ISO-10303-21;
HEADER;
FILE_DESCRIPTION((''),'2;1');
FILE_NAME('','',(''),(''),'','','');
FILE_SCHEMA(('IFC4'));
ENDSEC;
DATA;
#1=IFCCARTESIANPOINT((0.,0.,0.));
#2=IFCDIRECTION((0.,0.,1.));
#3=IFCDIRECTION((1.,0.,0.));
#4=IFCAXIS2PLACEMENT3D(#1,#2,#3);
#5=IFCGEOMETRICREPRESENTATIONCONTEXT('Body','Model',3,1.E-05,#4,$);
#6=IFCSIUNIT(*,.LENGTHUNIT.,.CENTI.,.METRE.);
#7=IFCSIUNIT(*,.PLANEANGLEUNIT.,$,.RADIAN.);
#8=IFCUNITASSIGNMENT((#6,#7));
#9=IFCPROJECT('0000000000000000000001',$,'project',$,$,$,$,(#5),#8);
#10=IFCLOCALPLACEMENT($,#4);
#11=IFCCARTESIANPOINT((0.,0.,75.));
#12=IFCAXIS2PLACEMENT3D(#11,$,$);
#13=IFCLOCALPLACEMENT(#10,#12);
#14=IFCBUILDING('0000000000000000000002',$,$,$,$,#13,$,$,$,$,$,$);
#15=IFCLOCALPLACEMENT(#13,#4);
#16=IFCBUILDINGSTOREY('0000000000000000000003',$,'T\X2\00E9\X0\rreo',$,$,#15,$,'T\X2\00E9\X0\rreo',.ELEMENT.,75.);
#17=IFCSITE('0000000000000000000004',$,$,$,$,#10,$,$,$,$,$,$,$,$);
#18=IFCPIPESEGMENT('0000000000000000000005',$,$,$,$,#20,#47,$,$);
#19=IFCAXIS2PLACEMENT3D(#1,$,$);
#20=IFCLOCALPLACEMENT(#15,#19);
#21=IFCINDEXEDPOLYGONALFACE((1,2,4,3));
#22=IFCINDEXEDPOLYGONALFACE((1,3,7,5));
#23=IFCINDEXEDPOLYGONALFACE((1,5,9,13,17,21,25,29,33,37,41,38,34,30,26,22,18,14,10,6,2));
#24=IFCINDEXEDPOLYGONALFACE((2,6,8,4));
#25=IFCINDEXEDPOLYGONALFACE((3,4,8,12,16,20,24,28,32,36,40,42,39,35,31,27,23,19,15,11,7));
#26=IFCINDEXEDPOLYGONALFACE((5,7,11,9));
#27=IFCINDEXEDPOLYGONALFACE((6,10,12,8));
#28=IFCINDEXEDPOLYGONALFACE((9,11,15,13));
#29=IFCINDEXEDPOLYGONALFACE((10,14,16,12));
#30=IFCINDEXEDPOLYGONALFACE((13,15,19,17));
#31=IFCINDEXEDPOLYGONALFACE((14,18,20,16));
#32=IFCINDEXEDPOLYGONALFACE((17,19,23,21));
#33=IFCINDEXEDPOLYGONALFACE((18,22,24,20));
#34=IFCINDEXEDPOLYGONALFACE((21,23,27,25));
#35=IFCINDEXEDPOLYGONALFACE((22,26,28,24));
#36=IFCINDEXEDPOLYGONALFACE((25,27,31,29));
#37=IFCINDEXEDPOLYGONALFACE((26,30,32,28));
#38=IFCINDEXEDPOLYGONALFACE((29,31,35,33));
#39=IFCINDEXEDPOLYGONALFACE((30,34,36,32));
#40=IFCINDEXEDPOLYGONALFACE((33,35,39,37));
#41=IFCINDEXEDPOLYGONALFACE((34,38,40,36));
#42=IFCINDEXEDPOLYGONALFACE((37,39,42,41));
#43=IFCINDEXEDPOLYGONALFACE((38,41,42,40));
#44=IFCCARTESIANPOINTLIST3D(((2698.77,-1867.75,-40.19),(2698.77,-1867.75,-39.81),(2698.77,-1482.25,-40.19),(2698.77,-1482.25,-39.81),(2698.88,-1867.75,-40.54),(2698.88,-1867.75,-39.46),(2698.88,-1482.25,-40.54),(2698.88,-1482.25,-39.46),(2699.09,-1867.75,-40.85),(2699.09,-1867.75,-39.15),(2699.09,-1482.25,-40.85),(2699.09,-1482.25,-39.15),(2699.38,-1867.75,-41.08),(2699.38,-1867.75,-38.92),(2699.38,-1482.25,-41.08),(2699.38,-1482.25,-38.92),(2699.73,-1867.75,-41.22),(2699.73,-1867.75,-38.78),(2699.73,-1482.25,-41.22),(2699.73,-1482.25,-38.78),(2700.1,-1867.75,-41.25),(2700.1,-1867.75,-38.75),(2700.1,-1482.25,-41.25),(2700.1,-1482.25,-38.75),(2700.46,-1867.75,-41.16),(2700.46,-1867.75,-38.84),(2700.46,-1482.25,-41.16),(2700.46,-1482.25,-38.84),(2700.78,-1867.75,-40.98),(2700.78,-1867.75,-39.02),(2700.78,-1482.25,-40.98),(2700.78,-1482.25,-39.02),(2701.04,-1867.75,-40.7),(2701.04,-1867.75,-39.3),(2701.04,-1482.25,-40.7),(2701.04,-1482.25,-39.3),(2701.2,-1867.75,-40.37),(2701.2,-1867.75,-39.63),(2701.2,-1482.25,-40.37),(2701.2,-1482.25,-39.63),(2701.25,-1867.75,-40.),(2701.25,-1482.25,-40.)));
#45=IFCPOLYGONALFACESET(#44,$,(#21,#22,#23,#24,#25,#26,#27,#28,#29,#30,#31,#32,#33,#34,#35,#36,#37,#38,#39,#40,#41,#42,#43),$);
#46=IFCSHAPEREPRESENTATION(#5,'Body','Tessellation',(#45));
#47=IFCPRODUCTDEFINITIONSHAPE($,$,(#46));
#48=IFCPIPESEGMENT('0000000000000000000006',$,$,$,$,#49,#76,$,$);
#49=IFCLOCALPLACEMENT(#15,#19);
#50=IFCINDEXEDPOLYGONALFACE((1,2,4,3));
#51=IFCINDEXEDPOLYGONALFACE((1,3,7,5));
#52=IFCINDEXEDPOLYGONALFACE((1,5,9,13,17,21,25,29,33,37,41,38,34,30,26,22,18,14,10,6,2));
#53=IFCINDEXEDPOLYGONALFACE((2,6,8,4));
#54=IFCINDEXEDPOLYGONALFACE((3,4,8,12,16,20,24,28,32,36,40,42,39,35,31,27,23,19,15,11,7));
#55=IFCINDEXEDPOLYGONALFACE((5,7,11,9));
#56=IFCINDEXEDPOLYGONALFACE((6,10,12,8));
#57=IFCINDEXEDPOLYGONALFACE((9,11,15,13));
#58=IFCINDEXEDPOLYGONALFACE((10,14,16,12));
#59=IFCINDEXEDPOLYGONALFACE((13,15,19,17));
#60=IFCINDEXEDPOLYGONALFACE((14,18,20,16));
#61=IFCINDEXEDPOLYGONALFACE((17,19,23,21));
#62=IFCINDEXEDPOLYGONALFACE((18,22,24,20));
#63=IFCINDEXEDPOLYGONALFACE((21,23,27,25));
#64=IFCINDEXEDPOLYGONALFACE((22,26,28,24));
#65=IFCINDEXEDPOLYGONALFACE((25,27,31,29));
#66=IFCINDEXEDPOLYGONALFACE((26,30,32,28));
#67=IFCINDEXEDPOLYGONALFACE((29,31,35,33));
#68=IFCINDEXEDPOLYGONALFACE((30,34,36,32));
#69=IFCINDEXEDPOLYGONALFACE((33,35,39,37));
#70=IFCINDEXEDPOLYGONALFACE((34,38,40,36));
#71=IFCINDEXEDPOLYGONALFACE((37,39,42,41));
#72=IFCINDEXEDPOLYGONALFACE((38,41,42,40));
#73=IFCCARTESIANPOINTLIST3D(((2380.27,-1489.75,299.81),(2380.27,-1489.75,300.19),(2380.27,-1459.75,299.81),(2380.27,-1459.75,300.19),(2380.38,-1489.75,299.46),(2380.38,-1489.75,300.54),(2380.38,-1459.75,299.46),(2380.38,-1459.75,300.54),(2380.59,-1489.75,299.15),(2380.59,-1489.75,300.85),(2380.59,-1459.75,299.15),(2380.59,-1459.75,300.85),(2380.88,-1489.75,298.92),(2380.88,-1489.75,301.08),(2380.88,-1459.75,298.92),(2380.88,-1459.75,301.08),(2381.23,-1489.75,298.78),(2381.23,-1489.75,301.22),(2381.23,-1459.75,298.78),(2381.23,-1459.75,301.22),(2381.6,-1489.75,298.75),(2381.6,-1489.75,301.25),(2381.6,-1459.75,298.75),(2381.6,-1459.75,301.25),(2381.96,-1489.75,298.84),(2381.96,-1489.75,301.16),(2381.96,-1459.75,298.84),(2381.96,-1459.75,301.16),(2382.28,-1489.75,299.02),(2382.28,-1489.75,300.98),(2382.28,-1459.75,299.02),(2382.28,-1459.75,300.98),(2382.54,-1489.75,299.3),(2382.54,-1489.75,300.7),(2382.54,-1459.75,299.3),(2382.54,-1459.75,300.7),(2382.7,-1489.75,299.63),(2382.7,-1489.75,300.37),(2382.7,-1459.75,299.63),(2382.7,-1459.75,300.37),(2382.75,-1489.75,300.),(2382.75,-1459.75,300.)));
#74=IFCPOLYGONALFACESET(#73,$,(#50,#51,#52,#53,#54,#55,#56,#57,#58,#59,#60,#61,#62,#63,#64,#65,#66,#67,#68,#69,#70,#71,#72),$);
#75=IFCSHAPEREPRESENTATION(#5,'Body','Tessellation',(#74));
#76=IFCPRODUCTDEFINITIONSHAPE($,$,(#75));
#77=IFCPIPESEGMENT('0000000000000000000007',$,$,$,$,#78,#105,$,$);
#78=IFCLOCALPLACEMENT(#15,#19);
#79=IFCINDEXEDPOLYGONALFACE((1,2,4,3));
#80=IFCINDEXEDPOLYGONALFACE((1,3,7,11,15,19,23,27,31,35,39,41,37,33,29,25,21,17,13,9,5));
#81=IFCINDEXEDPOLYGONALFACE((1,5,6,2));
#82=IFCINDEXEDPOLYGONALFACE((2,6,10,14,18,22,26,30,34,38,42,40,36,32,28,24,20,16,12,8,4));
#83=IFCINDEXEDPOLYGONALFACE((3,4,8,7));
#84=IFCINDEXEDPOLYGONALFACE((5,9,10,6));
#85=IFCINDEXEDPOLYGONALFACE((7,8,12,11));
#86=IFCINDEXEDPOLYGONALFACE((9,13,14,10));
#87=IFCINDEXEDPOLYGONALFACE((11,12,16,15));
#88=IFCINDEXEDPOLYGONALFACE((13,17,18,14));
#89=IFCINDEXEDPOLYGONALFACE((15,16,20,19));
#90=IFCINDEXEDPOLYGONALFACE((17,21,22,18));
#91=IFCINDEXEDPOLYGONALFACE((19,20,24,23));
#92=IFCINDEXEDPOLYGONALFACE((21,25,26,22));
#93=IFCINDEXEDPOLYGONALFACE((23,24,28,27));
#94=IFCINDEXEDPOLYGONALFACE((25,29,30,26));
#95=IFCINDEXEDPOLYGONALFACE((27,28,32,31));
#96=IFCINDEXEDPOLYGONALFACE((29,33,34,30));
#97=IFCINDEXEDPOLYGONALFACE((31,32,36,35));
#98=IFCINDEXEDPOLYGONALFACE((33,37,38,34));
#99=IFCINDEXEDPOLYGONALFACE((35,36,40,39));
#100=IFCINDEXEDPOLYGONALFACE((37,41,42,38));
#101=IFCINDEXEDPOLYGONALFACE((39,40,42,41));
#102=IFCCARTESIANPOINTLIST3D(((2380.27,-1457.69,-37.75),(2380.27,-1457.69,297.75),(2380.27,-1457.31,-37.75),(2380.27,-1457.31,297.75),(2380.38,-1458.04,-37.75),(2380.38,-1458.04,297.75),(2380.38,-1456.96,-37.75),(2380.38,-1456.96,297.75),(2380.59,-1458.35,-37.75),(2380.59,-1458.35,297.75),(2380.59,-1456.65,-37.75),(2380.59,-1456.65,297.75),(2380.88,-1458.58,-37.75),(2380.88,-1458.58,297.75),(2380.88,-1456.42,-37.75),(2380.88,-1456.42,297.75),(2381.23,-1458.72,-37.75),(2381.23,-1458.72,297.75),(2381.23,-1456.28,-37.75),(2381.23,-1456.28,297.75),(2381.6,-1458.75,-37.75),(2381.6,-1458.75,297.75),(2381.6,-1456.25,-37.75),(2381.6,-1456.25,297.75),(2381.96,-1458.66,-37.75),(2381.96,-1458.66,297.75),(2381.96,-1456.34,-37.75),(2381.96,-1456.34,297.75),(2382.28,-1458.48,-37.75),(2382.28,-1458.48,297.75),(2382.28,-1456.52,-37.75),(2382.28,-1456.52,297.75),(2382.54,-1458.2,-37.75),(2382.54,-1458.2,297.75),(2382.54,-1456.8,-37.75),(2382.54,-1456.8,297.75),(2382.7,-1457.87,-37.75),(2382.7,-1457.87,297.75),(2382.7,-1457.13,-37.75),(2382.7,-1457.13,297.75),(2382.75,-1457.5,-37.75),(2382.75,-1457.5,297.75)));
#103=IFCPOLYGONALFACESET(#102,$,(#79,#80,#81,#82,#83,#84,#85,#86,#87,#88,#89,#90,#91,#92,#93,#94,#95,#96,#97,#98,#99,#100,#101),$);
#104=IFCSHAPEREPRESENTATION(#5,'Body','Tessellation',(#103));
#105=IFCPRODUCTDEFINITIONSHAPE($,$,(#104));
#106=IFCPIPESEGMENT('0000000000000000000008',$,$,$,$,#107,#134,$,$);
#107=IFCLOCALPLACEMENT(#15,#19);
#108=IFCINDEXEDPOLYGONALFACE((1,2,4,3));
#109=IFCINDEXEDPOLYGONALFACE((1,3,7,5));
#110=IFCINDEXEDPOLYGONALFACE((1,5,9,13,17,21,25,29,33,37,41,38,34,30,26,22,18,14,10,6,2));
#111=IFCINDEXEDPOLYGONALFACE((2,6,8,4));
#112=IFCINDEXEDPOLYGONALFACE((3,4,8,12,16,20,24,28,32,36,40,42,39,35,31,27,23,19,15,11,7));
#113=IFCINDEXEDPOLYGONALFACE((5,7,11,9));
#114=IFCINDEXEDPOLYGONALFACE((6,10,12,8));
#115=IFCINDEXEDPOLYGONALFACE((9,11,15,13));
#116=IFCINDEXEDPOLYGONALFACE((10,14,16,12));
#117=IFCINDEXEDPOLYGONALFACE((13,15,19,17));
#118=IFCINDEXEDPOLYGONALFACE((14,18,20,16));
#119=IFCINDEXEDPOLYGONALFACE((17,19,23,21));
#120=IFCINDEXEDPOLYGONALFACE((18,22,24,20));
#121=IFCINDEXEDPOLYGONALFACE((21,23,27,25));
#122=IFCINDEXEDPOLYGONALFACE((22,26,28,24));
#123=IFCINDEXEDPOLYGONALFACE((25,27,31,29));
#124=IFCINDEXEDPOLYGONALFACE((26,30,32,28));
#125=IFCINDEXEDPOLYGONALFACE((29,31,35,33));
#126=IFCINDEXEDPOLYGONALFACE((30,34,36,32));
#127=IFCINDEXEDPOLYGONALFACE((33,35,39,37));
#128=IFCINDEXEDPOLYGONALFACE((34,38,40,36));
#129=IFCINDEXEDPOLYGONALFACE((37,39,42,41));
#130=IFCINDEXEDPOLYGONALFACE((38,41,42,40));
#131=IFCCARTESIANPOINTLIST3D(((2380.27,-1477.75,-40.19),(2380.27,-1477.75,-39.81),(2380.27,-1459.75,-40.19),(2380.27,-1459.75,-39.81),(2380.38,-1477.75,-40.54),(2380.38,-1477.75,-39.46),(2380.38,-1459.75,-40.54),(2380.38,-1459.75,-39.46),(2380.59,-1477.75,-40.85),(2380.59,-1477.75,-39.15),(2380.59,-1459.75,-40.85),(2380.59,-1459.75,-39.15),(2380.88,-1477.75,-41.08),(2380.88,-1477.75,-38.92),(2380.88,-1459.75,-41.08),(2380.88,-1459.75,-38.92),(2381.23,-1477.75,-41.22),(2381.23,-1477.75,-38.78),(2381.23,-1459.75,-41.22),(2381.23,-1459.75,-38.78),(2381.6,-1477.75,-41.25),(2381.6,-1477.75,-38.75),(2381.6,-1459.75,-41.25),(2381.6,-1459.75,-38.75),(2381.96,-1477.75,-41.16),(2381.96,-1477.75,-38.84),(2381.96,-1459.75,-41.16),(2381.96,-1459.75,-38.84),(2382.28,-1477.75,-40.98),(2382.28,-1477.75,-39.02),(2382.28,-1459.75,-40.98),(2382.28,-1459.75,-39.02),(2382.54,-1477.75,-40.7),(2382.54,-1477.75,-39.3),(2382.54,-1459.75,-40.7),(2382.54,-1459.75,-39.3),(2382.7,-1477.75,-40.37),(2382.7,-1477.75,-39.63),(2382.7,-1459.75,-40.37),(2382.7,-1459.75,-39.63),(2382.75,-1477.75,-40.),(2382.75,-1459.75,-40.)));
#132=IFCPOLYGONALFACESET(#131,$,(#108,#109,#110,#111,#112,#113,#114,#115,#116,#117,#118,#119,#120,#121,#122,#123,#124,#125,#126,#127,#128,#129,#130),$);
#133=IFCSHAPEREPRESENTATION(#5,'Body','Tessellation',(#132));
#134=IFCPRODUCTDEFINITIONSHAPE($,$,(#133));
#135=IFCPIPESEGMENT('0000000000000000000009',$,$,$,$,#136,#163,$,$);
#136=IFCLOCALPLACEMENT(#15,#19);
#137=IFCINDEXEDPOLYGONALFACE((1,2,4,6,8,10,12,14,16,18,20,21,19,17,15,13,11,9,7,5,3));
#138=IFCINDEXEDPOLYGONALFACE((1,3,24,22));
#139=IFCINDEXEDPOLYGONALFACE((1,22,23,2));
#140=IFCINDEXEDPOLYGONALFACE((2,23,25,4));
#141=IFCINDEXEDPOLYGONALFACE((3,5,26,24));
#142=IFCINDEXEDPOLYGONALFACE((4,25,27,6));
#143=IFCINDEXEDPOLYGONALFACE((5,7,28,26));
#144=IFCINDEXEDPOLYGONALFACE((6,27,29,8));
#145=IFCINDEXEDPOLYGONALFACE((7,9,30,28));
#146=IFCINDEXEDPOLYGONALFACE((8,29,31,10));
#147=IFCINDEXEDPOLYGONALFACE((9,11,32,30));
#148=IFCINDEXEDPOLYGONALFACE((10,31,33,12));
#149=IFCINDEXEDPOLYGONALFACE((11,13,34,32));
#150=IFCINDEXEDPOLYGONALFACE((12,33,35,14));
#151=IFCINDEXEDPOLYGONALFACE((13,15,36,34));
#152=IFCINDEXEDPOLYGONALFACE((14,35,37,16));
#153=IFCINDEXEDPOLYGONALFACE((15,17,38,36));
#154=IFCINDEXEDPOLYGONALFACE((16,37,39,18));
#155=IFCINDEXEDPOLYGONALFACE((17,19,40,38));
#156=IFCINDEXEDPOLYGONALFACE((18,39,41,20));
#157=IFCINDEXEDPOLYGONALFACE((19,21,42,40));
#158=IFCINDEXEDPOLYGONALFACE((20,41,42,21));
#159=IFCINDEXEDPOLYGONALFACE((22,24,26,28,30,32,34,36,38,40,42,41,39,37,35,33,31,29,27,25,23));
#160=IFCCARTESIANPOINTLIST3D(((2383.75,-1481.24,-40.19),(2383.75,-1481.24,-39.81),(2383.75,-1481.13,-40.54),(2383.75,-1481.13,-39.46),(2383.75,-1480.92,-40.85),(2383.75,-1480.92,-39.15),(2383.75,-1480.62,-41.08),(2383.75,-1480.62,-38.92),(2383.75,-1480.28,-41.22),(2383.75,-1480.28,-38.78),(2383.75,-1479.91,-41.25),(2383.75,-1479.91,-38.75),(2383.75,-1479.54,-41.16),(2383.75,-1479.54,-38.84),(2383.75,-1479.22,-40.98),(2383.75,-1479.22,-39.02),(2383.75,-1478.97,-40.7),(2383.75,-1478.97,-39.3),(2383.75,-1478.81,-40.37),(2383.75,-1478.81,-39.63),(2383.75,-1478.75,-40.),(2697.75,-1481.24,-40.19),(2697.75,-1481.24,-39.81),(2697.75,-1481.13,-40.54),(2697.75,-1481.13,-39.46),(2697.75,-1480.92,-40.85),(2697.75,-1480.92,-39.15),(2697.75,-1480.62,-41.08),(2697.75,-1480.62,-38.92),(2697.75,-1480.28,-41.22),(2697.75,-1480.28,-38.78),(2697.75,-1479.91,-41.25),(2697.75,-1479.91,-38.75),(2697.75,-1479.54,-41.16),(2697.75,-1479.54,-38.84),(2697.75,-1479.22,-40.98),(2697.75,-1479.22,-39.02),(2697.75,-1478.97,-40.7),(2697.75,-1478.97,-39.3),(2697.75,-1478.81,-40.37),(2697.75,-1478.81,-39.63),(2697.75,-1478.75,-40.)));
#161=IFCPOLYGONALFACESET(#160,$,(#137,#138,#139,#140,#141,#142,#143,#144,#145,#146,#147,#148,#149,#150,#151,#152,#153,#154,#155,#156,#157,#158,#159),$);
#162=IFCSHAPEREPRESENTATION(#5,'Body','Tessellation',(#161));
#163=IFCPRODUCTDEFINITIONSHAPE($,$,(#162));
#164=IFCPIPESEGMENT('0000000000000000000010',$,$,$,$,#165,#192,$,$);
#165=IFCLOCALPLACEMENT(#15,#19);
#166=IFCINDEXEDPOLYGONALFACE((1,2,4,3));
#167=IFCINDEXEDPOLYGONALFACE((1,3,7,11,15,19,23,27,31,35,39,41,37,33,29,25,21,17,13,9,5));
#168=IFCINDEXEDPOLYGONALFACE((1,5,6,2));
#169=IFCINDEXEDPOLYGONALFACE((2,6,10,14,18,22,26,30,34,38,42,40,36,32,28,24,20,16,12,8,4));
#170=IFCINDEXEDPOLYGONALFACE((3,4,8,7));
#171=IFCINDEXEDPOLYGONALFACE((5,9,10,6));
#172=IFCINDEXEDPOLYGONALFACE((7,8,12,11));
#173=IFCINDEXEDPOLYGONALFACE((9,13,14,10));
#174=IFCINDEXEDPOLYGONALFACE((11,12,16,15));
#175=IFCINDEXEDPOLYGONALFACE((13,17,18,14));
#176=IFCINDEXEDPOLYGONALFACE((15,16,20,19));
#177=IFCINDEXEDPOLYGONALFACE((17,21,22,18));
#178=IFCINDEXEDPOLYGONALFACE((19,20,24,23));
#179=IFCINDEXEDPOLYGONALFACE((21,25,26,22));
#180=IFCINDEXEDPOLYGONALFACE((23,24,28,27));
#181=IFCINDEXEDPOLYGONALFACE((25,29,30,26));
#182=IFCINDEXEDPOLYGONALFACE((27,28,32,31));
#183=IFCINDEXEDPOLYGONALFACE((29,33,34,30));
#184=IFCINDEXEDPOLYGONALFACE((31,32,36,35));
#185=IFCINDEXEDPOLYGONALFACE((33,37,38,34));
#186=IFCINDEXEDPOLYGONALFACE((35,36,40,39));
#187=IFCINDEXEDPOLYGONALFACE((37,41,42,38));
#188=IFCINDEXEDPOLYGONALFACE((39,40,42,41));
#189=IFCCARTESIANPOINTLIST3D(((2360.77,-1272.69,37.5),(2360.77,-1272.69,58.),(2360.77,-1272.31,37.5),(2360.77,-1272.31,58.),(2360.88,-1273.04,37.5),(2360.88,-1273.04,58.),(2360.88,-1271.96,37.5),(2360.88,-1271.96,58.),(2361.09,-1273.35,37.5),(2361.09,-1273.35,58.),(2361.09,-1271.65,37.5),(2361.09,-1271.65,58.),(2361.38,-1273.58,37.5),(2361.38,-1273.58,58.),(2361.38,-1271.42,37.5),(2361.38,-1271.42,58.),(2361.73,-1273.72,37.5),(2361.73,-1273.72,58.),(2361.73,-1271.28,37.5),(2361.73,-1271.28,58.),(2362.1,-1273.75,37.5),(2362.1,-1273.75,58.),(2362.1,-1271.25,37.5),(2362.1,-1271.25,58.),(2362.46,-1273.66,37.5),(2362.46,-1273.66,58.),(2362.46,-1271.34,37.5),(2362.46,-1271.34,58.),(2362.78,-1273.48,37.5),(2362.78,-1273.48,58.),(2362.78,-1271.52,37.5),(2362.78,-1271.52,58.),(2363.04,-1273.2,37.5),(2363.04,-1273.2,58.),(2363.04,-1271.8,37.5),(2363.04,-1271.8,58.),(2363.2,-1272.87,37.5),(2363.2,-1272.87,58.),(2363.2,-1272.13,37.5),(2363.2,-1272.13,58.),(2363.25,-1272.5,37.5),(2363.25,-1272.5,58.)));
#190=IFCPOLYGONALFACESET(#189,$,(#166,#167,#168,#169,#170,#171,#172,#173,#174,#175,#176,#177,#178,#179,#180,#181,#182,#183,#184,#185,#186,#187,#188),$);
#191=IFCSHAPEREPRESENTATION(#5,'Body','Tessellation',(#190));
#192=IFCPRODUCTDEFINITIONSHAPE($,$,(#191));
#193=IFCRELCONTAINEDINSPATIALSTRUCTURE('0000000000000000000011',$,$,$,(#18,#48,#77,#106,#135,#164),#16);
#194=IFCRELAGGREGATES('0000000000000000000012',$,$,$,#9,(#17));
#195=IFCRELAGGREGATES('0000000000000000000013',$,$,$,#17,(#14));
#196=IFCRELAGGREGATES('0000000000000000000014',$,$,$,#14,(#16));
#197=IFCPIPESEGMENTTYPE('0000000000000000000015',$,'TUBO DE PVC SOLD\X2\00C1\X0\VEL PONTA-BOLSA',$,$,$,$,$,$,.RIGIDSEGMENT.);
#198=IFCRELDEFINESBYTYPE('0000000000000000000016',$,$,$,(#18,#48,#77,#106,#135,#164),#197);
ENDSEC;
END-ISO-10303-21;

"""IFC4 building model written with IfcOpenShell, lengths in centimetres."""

from ifc_helpers import new_model, si_unit, frame, origin_with_axes, origin_2d_with_axis, place, context, project, spatial, circle, extrude, type_object, element, save


model = new_model("IFC4")

# Units and contexts
model_context = context("Model", 3, precision=1e-05, world=origin_with_axes(), identifier="Body")
ifc_project = project(units=[si_unit("LENGTHUNIT", "METRE", prefix="CENTI"), si_unit("PLANEANGLEUNIT", "RADIAN")], contexts=[model_context])

# Site, building, storey
site_placement = place(None, origin_with_axes())
site = spatial("IfcSite", under=ifc_project, at=site_placement)
building_placement = place(site_placement, frame((0.0, 0.0, 75.0)))
building = spatial("IfcBuilding", under=site, at=building_placement)
storey_placement = place(building_placement, origin_with_axes())
storey = spatial("IfcBuildingStorey", under=building, at=storey_placement, Name="Térreo", LongName="Térreo", CompositionType="ELEMENT", Elevation=75.0)

# Pipe segments
pipe_segment_type_1 = type_object("IfcPipeSegmentType", Name="TUBO DE PVC SOLDÁVEL PONTA-BOLSA", PredefinedType="RIGIDSEGMENT")
pipe_segment_1_placement = place(storey_placement, frame((2700.0, -1675.0, -38.75), z_axis=(0.0, 0.0, 1.0), x_axis=(1.0, 0.0, 0.0)))
element("IfcPipeSegment", 1, at=pipe_segment_1_placement, inside=storey, type_object=pipe_segment_type_1, context=model_context, shape_type="SolidModel", body=[
    extrude(circle(Radius=1.25, at=origin_2d_with_axis()), frame((0.0, -192.75, -1.25), z_axis=(0.0, 1.0, 0.0), x_axis=(1.0, 0.0, 0.0)), (0.0, 0.0, 1.0), 385.5),
])
pipe_segment_2_placement = place(storey_placement, frame((2381.5, -1474.75, 301.25), z_axis=(0.0, 0.0, 1.0), x_axis=(1.0, 0.0, 0.0)))
element("IfcPipeSegment", 2, at=pipe_segment_2_placement, inside=storey, type_object=pipe_segment_type_1, context=model_context, shape_type="SolidModel", body=[
    extrude(circle(Radius=1.25, at=origin_2d_with_axis()), frame((0.0, 15.0, -1.25), z_axis=(0.0, -1.0, 0.0), x_axis=(1.0, 0.0, 0.0)), (0.0, 0.0, 1.0), 30.0),
])
pipe_segment_3_placement = place(storey_placement, frame((2381.5, -1457.5, 297.75), z_axis=(0.0, 0.0, 1.0), x_axis=(1.0, 0.0, 0.0)))
element("IfcPipeSegment", 3, at=pipe_segment_3_placement, inside=storey, type_object=pipe_segment_type_1, context=model_context, shape_type="SolidModel", body=[
    extrude(circle(Radius=1.25, at=origin_2d_with_axis()), frame((0.0, 0.0, -335.5), z_axis=(0.0, 0.0, 1.0), x_axis=(1.0, 0.0, 0.0)), (0.0, 0.0, 1.0), 335.5),
])
pipe_segment_4_placement = place(storey_placement, frame((2381.5, -1468.75, -38.75), z_axis=(0.0, 0.0, 1.0), x_axis=(1.0, 0.0, 0.0)))
element("IfcPipeSegment", 4, at=pipe_segment_4_placement, inside=storey, type_object=pipe_segment_type_1, context=model_context, shape_type="SolidModel", body=[
    extrude(circle(Radius=1.25, at=origin_2d_with_axis()), frame((0.0, -9.0, -1.25), z_axis=(0.0, 1.0, 0.0), x_axis=(1.0, 0.0, 0.0)), (0.0, 0.0, 1.0), 18.0),
])
pipe_segment_5_placement = place(storey_placement, frame((2540.75, -1480.0, -38.75), z_axis=(0.0, 0.0, 1.0), x_axis=(1.0, 0.0, 0.0)))
element("IfcPipeSegment", 5, at=pipe_segment_5_placement, inside=storey, type_object=pipe_segment_type_1, context=model_context, shape_type="SolidModel", body=[
    extrude(circle(Radius=1.25, at=origin_2d_with_axis()), frame((157.0, 0.0, -1.25), z_axis=(-1.0, 0.0, 0.0), x_axis=(0.0, 1.0, 0.0)), (0.0, 0.0, 1.0), 314.0),
])
pipe_segment_6_placement = place(storey_placement, frame((2362.0, -1272.5, 58.0), z_axis=(0.0, 0.0, 1.0), x_axis=(1.0, 0.0, 0.0)))
element("IfcPipeSegment", 6, at=pipe_segment_6_placement, inside=storey, type_object=pipe_segment_type_1, context=model_context, shape_type="SolidModel", body=[
    extrude(circle(Radius=1.25, at=origin_2d_with_axis()), frame((0.0, 0.0, -20.5), z_axis=(0.0, 0.0, 1.0), x_axis=(1.0, 0.0, 0.0)), (0.0, 0.0, 1.0), 20.5),
])

save(model, "model.ifc")
